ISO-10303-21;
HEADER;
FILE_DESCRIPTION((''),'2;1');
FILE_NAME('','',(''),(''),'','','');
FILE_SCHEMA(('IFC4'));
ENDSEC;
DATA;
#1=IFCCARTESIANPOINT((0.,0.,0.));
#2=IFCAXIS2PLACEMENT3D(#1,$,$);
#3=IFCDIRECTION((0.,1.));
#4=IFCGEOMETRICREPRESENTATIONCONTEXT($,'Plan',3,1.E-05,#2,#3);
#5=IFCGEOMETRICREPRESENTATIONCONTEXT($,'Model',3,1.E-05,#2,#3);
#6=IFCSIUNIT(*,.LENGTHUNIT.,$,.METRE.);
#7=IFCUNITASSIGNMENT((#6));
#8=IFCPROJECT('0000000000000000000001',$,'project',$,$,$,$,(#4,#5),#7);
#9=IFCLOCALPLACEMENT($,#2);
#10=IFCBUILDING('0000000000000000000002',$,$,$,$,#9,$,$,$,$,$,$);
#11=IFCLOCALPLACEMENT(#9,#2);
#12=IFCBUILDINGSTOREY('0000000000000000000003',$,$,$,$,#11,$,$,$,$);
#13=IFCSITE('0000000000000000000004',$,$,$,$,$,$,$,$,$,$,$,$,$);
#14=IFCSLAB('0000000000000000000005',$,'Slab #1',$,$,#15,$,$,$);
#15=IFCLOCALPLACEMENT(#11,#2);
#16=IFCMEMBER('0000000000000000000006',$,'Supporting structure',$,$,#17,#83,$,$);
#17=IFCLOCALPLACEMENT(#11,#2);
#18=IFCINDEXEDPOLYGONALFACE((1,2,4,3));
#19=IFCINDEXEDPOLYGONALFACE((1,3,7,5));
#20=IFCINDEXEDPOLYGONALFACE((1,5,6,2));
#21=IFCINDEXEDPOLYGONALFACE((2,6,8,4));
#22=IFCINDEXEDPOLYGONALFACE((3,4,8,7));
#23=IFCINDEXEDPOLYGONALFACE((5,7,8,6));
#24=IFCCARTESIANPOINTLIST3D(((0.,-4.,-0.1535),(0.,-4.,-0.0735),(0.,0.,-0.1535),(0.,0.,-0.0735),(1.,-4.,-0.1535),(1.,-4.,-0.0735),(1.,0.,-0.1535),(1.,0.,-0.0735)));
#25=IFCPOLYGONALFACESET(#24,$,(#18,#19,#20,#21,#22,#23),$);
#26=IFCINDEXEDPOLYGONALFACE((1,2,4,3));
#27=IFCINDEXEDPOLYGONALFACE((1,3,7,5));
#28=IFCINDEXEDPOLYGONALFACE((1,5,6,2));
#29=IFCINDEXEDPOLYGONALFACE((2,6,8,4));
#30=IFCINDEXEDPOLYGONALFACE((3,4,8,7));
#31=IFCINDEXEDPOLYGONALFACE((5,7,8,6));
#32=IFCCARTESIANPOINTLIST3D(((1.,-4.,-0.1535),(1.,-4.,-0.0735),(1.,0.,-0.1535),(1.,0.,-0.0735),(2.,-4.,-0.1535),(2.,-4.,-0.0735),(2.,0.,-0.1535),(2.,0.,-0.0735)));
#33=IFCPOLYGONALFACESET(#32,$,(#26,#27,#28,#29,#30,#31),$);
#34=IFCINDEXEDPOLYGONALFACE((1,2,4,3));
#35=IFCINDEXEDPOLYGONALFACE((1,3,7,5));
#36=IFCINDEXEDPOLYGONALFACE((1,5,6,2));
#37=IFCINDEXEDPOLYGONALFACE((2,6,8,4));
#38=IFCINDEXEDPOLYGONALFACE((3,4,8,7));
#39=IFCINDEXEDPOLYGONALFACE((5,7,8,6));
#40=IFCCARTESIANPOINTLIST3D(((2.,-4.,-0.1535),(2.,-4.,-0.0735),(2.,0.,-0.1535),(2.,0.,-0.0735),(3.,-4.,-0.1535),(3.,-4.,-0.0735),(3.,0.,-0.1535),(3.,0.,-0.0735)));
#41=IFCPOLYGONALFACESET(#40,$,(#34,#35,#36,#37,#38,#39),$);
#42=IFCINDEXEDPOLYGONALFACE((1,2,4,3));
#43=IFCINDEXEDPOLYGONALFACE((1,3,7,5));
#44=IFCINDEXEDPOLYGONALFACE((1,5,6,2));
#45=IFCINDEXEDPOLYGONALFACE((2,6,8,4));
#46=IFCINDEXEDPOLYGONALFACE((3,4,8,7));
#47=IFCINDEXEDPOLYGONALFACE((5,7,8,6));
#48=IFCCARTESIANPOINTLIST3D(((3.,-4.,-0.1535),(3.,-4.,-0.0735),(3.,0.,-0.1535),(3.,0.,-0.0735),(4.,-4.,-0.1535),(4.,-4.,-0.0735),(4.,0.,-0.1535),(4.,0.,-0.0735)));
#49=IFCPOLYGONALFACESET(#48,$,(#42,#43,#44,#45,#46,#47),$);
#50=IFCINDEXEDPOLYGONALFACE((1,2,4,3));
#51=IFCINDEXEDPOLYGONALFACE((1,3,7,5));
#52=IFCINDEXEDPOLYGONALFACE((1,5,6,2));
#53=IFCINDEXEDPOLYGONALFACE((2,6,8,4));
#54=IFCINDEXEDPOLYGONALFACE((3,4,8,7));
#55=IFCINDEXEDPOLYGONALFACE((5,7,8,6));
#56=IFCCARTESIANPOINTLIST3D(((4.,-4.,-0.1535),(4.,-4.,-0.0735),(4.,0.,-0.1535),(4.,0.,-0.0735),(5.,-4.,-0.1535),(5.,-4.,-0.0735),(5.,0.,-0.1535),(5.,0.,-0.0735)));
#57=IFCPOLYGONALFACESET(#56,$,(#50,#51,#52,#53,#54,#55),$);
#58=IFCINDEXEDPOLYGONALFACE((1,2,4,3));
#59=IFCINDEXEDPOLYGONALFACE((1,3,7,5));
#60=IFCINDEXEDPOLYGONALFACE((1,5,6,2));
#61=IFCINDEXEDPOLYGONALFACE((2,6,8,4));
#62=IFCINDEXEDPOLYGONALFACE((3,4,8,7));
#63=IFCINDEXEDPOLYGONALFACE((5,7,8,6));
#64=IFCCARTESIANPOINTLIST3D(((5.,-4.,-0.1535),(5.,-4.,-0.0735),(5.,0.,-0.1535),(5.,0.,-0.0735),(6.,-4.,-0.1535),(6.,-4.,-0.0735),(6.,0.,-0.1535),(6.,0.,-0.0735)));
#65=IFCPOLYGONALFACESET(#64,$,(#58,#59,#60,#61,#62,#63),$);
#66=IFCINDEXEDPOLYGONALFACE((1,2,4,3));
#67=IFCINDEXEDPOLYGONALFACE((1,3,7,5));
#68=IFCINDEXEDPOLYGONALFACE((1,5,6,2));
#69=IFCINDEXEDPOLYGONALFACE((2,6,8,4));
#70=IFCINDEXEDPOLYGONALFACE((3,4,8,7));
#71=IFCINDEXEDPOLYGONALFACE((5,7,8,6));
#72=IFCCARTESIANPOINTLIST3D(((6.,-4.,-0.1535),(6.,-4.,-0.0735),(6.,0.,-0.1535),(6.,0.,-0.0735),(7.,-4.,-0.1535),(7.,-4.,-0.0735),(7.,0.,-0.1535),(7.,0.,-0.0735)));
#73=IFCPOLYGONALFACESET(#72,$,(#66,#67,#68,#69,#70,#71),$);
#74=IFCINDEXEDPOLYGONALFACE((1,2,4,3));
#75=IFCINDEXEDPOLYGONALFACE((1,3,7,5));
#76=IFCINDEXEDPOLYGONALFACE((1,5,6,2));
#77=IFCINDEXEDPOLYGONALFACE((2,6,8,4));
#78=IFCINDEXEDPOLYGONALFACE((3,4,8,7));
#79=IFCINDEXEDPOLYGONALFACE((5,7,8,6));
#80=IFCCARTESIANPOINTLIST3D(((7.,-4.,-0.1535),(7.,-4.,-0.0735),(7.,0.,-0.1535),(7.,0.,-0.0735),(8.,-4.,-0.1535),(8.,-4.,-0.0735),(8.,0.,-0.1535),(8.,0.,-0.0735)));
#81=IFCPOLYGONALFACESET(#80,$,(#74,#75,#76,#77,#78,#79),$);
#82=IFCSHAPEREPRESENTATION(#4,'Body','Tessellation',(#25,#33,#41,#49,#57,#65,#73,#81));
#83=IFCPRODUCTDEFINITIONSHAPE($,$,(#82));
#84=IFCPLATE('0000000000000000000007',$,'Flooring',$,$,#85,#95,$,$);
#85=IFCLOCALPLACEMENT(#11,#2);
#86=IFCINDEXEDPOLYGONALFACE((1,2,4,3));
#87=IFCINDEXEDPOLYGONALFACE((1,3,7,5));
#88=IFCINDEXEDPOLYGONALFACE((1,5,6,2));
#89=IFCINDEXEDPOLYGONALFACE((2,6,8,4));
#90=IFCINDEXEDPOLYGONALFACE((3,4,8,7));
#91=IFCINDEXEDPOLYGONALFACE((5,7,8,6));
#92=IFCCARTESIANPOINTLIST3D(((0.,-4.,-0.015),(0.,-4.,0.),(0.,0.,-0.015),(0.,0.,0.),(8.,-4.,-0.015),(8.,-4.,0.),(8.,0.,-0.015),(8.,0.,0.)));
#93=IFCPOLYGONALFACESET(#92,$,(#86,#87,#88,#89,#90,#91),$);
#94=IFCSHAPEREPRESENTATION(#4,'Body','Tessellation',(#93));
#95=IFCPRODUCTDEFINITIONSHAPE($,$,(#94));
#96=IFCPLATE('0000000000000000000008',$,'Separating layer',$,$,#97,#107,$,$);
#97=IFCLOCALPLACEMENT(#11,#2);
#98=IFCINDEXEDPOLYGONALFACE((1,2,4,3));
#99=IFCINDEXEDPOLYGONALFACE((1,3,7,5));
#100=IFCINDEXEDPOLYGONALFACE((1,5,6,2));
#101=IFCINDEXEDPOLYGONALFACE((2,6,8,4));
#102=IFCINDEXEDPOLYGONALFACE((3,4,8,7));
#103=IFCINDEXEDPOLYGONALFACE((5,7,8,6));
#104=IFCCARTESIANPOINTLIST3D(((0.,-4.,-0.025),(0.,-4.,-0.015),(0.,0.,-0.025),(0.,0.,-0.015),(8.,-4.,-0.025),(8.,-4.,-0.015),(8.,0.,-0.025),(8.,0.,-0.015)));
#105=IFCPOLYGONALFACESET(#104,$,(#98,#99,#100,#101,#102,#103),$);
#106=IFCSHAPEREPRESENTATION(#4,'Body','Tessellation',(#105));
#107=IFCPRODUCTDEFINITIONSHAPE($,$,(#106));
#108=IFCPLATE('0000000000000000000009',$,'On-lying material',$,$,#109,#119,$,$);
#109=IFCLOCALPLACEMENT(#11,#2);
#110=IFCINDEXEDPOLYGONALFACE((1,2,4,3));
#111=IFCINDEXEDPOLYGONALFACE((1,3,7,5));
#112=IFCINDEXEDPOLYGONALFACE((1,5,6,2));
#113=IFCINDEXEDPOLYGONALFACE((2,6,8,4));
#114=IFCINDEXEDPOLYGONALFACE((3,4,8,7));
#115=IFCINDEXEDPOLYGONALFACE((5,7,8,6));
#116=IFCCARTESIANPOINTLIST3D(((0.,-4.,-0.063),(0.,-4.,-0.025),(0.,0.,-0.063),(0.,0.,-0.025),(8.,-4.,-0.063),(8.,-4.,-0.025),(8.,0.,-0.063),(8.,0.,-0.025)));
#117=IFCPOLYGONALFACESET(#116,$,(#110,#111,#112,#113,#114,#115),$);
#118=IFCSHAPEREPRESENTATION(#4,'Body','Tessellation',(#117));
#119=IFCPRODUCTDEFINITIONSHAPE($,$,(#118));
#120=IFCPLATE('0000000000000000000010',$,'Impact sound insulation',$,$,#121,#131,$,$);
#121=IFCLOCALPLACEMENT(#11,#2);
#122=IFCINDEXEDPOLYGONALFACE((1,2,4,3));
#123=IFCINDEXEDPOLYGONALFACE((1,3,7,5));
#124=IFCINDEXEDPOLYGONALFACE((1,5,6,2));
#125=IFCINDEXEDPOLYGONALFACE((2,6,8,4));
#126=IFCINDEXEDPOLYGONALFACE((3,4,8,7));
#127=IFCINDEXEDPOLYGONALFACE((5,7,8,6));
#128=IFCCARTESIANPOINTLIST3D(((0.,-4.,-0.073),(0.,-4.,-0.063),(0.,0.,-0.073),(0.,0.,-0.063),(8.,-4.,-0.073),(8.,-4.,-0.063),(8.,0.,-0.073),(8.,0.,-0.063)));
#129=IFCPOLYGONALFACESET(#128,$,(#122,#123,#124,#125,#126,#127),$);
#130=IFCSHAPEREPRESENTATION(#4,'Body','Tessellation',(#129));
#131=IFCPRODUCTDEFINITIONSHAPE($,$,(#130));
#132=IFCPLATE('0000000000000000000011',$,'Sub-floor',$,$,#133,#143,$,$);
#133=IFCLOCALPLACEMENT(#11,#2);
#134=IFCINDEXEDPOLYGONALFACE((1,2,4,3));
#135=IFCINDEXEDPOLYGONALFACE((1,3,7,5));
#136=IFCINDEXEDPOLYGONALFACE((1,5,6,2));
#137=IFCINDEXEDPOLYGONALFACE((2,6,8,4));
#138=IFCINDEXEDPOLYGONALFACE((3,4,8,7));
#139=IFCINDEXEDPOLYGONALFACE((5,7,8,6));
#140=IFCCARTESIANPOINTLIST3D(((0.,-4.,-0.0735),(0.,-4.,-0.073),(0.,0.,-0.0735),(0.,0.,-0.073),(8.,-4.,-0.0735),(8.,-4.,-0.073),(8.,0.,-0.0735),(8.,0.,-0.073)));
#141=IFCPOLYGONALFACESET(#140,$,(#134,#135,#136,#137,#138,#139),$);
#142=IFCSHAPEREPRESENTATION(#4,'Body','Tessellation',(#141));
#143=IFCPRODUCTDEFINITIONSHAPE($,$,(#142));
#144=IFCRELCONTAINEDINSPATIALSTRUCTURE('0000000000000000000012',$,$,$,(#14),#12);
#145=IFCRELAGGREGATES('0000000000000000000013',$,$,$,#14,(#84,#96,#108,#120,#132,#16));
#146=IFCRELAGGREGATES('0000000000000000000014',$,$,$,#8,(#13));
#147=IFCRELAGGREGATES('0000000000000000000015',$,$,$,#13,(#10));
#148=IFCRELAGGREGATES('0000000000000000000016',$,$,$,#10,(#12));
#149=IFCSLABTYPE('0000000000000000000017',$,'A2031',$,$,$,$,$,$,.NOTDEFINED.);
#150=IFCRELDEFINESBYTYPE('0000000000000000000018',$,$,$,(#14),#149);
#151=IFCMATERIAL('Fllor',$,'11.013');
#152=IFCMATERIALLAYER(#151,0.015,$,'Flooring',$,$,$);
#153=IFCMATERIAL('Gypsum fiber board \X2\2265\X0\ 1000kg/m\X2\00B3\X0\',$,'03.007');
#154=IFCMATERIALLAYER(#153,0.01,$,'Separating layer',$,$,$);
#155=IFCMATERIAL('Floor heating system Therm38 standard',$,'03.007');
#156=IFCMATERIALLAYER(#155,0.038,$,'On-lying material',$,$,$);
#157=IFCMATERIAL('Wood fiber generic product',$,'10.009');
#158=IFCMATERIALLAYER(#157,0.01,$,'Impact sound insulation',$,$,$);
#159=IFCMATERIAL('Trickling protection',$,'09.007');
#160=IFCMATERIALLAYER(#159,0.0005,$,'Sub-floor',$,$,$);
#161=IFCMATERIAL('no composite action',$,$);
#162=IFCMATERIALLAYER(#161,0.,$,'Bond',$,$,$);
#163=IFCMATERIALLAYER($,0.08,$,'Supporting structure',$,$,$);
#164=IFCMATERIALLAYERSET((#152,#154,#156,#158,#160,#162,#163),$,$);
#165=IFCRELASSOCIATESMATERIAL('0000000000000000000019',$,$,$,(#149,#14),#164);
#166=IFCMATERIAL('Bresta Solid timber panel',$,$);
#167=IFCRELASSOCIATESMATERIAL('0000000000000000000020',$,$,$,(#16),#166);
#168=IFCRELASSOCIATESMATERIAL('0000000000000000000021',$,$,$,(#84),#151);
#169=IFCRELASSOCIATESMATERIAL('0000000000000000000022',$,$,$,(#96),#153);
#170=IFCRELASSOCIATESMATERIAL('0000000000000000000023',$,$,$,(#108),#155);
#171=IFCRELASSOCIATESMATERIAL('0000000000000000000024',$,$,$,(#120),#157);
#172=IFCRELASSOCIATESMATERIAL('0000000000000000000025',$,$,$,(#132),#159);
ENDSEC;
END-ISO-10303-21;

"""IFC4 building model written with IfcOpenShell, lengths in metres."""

from ifc_helpers import new_model, si_unit, direction, frame, frame_2d, origin, origin_with_axes, place, context, project, spatial, rectangle, extrude, material, layer, layer_set, type_object, element, aggregate, save


model = new_model("IFC4")

# Units and contexts
plan_context = context("Plan", 3, precision=1e-05, world=origin(), true_north=direction((0.0, 1.0)))
model_context = context("Model", 3, precision=1e-05, world=origin(), true_north=direction((0.0, 1.0)))
ifc_project = project(units=[si_unit("LENGTHUNIT", "METRE")], contexts=[plan_context, model_context])

# Site, building, storey
site = spatial("IfcSite", under=ifc_project)
building_placement = place(None, origin())
building = spatial("IfcBuilding", under=site, at=building_placement)
storey_placement = place(building_placement, origin())
storey = spatial("IfcBuildingStorey", under=building, at=storey_placement)

# Slab, member, plates
ifc_material_1 = material(Name="Fllor", Category="11.013")
ifc_layer_1 = layer(ifc_material_1, 0.015, Name="Flooring")
ifc_material_2 = material(Name="Gypsum fiber board ≥ 1000kg/m³", Category="03.007")
ifc_layer_2 = layer(ifc_material_2, 0.01, Name="Separating layer")
ifc_material_3 = material(Name="Floor heating system Therm38 standard", Category="03.007")
ifc_layer_3 = layer(ifc_material_3, 0.038, Name="On-lying material")
ifc_material_4 = material(Name="Wood fiber generic product", Category="10.009")
ifc_layer_4 = layer(ifc_material_4, 0.01, Name="Impact sound insulation")
ifc_material_5 = material(Name="Trickling protection", Category="09.007")
ifc_layer_5 = layer(ifc_material_5, 0.0005, Name="Sub-floor")
ifc_material_6 = material(Name="no composite action")
ifc_layer_6 = layer(ifc_material_6, 0.0, Name="Bond")
ifc_layer_7 = layer(None, 0.08, Name="Supporting structure")
ifc_layer_set = layer_set([ifc_layer_1, ifc_layer_2, ifc_layer_3, ifc_layer_4, ifc_layer_5, ifc_layer_6, ifc_layer_7])
slab_type = type_object("IfcSlabType", Name="A2031", PredefinedType="NOTDEFINED", material=ifc_layer_set)
slab_placement = place(None, frame((0.0, 0.0, 0.0), z_axis=(0.0, 0.0, -1.0), x_axis=(1.0, 0.0, 0.0)))
slab = element("IfcSlab", 1, at=slab_placement, inside=storey, type_object=slab_type, material=ifc_layer_set, Name="Slab #1")
ifc_material_7 = material(Name="Bresta Solid timber panel")
member_placement = place(slab_placement, origin())
member = element("IfcMember", 2, at=member_placement, material=ifc_material_7, Name="Supporting structure", context=plan_context, shape_type="SweptSolid", body=[
    extrude(rectangle(XDim=1.0, YDim=0.08, at=frame_2d((0.5, 0.04), x_axis=(1.0, 0.0))), frame((0.0, 4.0, 0.0735), z_axis=(0.0, -1.0, 0.0), x_axis=(1.0, 0.0, 0.0)), (0.0, 0.0, 1.0), 4.0),
    extrude(rectangle(XDim=1.0, YDim=0.08, at=frame_2d((0.5, 0.04), x_axis=(1.0, 0.0))), frame((1.0, 4.0, 0.0735), z_axis=(0.0, -1.0, 0.0), x_axis=(1.0, 0.0, 0.0)), (0.0, 0.0, 1.0), 4.0),
    extrude(rectangle(XDim=1.0, YDim=0.08, at=frame_2d((0.5, 0.04), x_axis=(1.0, 0.0))), frame((2.0, 4.0, 0.0735), z_axis=(0.0, -1.0, 0.0), x_axis=(1.0, 0.0, 0.0)), (0.0, 0.0, 1.0), 4.0),
    extrude(rectangle(XDim=1.0, YDim=0.08, at=frame_2d((0.5, 0.04), x_axis=(1.0, 0.0))), frame((3.0, 4.0, 0.0735), z_axis=(0.0, -1.0, 0.0), x_axis=(1.0, 0.0, 0.0)), (0.0, 0.0, 1.0), 4.0),
    extrude(rectangle(XDim=1.0, YDim=0.08, at=frame_2d((0.5, 0.04), x_axis=(1.0, 0.0))), frame((4.0, 4.0, 0.0735), z_axis=(0.0, -1.0, 0.0), x_axis=(1.0, 0.0, 0.0)), (0.0, 0.0, 1.0), 4.0),
    extrude(rectangle(XDim=1.0, YDim=0.08, at=frame_2d((0.5, 0.04), x_axis=(1.0, 0.0))), frame((5.0, 4.0, 0.0735), z_axis=(0.0, -1.0, 0.0), x_axis=(1.0, 0.0, 0.0)), (0.0, 0.0, 1.0), 4.0),
    extrude(rectangle(XDim=1.0, YDim=0.08, at=frame_2d((0.5, 0.04), x_axis=(1.0, 0.0))), frame((6.0, 4.0, 0.0735), z_axis=(0.0, -1.0, 0.0), x_axis=(1.0, 0.0, 0.0)), (0.0, 0.0, 1.0), 4.0),
    extrude(rectangle(XDim=1.0, YDim=0.08, at=frame_2d((0.5, 0.04), x_axis=(1.0, 0.0))), frame((7.0, 4.0, 0.0735), z_axis=(0.0, -1.0, 0.0), x_axis=(1.0, 0.0, 0.0)), (0.0, 0.0, 1.0), 4.0),
])
plate_1_placement = place(slab_placement, origin())
plate_1 = element("IfcPlate", 3, at=plate_1_placement, material=ifc_material_1, Name="Flooring", context=plan_context, shape_type="SweptSolid", body=[
    extrude(rectangle(XDim=8.0, YDim=4.0, at=frame_2d((4.0, 2.0), x_axis=(1.0, 0.0))), origin_with_axes(), (0.0, 0.0, 1.0), 0.015),
])
plate_2_placement = place(slab_placement, origin())
plate_2 = element("IfcPlate", 4, at=plate_2_placement, material=ifc_material_2, Name="Separating layer", context=plan_context, shape_type="SweptSolid", body=[
    extrude(rectangle(XDim=8.0, YDim=4.0, at=frame_2d((4.0, 2.0), x_axis=(1.0, 0.0))), frame((0.0, 0.0, 0.015), z_axis=(0.0, 0.0, 1.0), x_axis=(1.0, 0.0, 0.0)), (0.0, 0.0, 1.0), 0.01),
])
plate_3_placement = place(slab_placement, origin())
plate_3 = element("IfcPlate", 5, at=plate_3_placement, material=ifc_material_3, Name="On-lying material", context=plan_context, shape_type="SweptSolid", body=[
    extrude(rectangle(XDim=8.0, YDim=4.0, at=frame_2d((4.0, 2.0), x_axis=(1.0, 0.0))), frame((0.0, 0.0, 0.025), z_axis=(0.0, 0.0, 1.0), x_axis=(1.0, 0.0, 0.0)), (0.0, 0.0, 1.0), 0.038),
])
plate_4_placement = place(slab_placement, origin())
plate_4 = element("IfcPlate", 6, at=plate_4_placement, material=ifc_material_4, Name="Impact sound insulation", context=plan_context, shape_type="SweptSolid", body=[
    extrude(rectangle(XDim=8.0, YDim=4.0, at=frame_2d((4.0, 2.0), x_axis=(1.0, 0.0))), frame((0.0, 0.0, 0.063), z_axis=(0.0, 0.0, 1.0), x_axis=(1.0, 0.0, 0.0)), (0.0, 0.0, 1.0), 0.01),
])
plate_5_placement = place(slab_placement, origin())
plate_5 = element("IfcPlate", 7, at=plate_5_placement, material=ifc_material_5, Name="Sub-floor", context=plan_context, shape_type="SweptSolid", body=[
    extrude(rectangle(XDim=8.0, YDim=4.0, at=frame_2d((4.0, 2.0), x_axis=(1.0, 0.0))), frame((0.0, 0.0, 0.073), z_axis=(0.0, 0.0, 1.0), x_axis=(1.0, 0.0, 0.0)), (0.0, 0.0, 1.0), 0.0005),
])
aggregate(slab, [plate_1, plate_2, plate_3, plate_4, plate_5, member])

save(model, "model.ifc")
